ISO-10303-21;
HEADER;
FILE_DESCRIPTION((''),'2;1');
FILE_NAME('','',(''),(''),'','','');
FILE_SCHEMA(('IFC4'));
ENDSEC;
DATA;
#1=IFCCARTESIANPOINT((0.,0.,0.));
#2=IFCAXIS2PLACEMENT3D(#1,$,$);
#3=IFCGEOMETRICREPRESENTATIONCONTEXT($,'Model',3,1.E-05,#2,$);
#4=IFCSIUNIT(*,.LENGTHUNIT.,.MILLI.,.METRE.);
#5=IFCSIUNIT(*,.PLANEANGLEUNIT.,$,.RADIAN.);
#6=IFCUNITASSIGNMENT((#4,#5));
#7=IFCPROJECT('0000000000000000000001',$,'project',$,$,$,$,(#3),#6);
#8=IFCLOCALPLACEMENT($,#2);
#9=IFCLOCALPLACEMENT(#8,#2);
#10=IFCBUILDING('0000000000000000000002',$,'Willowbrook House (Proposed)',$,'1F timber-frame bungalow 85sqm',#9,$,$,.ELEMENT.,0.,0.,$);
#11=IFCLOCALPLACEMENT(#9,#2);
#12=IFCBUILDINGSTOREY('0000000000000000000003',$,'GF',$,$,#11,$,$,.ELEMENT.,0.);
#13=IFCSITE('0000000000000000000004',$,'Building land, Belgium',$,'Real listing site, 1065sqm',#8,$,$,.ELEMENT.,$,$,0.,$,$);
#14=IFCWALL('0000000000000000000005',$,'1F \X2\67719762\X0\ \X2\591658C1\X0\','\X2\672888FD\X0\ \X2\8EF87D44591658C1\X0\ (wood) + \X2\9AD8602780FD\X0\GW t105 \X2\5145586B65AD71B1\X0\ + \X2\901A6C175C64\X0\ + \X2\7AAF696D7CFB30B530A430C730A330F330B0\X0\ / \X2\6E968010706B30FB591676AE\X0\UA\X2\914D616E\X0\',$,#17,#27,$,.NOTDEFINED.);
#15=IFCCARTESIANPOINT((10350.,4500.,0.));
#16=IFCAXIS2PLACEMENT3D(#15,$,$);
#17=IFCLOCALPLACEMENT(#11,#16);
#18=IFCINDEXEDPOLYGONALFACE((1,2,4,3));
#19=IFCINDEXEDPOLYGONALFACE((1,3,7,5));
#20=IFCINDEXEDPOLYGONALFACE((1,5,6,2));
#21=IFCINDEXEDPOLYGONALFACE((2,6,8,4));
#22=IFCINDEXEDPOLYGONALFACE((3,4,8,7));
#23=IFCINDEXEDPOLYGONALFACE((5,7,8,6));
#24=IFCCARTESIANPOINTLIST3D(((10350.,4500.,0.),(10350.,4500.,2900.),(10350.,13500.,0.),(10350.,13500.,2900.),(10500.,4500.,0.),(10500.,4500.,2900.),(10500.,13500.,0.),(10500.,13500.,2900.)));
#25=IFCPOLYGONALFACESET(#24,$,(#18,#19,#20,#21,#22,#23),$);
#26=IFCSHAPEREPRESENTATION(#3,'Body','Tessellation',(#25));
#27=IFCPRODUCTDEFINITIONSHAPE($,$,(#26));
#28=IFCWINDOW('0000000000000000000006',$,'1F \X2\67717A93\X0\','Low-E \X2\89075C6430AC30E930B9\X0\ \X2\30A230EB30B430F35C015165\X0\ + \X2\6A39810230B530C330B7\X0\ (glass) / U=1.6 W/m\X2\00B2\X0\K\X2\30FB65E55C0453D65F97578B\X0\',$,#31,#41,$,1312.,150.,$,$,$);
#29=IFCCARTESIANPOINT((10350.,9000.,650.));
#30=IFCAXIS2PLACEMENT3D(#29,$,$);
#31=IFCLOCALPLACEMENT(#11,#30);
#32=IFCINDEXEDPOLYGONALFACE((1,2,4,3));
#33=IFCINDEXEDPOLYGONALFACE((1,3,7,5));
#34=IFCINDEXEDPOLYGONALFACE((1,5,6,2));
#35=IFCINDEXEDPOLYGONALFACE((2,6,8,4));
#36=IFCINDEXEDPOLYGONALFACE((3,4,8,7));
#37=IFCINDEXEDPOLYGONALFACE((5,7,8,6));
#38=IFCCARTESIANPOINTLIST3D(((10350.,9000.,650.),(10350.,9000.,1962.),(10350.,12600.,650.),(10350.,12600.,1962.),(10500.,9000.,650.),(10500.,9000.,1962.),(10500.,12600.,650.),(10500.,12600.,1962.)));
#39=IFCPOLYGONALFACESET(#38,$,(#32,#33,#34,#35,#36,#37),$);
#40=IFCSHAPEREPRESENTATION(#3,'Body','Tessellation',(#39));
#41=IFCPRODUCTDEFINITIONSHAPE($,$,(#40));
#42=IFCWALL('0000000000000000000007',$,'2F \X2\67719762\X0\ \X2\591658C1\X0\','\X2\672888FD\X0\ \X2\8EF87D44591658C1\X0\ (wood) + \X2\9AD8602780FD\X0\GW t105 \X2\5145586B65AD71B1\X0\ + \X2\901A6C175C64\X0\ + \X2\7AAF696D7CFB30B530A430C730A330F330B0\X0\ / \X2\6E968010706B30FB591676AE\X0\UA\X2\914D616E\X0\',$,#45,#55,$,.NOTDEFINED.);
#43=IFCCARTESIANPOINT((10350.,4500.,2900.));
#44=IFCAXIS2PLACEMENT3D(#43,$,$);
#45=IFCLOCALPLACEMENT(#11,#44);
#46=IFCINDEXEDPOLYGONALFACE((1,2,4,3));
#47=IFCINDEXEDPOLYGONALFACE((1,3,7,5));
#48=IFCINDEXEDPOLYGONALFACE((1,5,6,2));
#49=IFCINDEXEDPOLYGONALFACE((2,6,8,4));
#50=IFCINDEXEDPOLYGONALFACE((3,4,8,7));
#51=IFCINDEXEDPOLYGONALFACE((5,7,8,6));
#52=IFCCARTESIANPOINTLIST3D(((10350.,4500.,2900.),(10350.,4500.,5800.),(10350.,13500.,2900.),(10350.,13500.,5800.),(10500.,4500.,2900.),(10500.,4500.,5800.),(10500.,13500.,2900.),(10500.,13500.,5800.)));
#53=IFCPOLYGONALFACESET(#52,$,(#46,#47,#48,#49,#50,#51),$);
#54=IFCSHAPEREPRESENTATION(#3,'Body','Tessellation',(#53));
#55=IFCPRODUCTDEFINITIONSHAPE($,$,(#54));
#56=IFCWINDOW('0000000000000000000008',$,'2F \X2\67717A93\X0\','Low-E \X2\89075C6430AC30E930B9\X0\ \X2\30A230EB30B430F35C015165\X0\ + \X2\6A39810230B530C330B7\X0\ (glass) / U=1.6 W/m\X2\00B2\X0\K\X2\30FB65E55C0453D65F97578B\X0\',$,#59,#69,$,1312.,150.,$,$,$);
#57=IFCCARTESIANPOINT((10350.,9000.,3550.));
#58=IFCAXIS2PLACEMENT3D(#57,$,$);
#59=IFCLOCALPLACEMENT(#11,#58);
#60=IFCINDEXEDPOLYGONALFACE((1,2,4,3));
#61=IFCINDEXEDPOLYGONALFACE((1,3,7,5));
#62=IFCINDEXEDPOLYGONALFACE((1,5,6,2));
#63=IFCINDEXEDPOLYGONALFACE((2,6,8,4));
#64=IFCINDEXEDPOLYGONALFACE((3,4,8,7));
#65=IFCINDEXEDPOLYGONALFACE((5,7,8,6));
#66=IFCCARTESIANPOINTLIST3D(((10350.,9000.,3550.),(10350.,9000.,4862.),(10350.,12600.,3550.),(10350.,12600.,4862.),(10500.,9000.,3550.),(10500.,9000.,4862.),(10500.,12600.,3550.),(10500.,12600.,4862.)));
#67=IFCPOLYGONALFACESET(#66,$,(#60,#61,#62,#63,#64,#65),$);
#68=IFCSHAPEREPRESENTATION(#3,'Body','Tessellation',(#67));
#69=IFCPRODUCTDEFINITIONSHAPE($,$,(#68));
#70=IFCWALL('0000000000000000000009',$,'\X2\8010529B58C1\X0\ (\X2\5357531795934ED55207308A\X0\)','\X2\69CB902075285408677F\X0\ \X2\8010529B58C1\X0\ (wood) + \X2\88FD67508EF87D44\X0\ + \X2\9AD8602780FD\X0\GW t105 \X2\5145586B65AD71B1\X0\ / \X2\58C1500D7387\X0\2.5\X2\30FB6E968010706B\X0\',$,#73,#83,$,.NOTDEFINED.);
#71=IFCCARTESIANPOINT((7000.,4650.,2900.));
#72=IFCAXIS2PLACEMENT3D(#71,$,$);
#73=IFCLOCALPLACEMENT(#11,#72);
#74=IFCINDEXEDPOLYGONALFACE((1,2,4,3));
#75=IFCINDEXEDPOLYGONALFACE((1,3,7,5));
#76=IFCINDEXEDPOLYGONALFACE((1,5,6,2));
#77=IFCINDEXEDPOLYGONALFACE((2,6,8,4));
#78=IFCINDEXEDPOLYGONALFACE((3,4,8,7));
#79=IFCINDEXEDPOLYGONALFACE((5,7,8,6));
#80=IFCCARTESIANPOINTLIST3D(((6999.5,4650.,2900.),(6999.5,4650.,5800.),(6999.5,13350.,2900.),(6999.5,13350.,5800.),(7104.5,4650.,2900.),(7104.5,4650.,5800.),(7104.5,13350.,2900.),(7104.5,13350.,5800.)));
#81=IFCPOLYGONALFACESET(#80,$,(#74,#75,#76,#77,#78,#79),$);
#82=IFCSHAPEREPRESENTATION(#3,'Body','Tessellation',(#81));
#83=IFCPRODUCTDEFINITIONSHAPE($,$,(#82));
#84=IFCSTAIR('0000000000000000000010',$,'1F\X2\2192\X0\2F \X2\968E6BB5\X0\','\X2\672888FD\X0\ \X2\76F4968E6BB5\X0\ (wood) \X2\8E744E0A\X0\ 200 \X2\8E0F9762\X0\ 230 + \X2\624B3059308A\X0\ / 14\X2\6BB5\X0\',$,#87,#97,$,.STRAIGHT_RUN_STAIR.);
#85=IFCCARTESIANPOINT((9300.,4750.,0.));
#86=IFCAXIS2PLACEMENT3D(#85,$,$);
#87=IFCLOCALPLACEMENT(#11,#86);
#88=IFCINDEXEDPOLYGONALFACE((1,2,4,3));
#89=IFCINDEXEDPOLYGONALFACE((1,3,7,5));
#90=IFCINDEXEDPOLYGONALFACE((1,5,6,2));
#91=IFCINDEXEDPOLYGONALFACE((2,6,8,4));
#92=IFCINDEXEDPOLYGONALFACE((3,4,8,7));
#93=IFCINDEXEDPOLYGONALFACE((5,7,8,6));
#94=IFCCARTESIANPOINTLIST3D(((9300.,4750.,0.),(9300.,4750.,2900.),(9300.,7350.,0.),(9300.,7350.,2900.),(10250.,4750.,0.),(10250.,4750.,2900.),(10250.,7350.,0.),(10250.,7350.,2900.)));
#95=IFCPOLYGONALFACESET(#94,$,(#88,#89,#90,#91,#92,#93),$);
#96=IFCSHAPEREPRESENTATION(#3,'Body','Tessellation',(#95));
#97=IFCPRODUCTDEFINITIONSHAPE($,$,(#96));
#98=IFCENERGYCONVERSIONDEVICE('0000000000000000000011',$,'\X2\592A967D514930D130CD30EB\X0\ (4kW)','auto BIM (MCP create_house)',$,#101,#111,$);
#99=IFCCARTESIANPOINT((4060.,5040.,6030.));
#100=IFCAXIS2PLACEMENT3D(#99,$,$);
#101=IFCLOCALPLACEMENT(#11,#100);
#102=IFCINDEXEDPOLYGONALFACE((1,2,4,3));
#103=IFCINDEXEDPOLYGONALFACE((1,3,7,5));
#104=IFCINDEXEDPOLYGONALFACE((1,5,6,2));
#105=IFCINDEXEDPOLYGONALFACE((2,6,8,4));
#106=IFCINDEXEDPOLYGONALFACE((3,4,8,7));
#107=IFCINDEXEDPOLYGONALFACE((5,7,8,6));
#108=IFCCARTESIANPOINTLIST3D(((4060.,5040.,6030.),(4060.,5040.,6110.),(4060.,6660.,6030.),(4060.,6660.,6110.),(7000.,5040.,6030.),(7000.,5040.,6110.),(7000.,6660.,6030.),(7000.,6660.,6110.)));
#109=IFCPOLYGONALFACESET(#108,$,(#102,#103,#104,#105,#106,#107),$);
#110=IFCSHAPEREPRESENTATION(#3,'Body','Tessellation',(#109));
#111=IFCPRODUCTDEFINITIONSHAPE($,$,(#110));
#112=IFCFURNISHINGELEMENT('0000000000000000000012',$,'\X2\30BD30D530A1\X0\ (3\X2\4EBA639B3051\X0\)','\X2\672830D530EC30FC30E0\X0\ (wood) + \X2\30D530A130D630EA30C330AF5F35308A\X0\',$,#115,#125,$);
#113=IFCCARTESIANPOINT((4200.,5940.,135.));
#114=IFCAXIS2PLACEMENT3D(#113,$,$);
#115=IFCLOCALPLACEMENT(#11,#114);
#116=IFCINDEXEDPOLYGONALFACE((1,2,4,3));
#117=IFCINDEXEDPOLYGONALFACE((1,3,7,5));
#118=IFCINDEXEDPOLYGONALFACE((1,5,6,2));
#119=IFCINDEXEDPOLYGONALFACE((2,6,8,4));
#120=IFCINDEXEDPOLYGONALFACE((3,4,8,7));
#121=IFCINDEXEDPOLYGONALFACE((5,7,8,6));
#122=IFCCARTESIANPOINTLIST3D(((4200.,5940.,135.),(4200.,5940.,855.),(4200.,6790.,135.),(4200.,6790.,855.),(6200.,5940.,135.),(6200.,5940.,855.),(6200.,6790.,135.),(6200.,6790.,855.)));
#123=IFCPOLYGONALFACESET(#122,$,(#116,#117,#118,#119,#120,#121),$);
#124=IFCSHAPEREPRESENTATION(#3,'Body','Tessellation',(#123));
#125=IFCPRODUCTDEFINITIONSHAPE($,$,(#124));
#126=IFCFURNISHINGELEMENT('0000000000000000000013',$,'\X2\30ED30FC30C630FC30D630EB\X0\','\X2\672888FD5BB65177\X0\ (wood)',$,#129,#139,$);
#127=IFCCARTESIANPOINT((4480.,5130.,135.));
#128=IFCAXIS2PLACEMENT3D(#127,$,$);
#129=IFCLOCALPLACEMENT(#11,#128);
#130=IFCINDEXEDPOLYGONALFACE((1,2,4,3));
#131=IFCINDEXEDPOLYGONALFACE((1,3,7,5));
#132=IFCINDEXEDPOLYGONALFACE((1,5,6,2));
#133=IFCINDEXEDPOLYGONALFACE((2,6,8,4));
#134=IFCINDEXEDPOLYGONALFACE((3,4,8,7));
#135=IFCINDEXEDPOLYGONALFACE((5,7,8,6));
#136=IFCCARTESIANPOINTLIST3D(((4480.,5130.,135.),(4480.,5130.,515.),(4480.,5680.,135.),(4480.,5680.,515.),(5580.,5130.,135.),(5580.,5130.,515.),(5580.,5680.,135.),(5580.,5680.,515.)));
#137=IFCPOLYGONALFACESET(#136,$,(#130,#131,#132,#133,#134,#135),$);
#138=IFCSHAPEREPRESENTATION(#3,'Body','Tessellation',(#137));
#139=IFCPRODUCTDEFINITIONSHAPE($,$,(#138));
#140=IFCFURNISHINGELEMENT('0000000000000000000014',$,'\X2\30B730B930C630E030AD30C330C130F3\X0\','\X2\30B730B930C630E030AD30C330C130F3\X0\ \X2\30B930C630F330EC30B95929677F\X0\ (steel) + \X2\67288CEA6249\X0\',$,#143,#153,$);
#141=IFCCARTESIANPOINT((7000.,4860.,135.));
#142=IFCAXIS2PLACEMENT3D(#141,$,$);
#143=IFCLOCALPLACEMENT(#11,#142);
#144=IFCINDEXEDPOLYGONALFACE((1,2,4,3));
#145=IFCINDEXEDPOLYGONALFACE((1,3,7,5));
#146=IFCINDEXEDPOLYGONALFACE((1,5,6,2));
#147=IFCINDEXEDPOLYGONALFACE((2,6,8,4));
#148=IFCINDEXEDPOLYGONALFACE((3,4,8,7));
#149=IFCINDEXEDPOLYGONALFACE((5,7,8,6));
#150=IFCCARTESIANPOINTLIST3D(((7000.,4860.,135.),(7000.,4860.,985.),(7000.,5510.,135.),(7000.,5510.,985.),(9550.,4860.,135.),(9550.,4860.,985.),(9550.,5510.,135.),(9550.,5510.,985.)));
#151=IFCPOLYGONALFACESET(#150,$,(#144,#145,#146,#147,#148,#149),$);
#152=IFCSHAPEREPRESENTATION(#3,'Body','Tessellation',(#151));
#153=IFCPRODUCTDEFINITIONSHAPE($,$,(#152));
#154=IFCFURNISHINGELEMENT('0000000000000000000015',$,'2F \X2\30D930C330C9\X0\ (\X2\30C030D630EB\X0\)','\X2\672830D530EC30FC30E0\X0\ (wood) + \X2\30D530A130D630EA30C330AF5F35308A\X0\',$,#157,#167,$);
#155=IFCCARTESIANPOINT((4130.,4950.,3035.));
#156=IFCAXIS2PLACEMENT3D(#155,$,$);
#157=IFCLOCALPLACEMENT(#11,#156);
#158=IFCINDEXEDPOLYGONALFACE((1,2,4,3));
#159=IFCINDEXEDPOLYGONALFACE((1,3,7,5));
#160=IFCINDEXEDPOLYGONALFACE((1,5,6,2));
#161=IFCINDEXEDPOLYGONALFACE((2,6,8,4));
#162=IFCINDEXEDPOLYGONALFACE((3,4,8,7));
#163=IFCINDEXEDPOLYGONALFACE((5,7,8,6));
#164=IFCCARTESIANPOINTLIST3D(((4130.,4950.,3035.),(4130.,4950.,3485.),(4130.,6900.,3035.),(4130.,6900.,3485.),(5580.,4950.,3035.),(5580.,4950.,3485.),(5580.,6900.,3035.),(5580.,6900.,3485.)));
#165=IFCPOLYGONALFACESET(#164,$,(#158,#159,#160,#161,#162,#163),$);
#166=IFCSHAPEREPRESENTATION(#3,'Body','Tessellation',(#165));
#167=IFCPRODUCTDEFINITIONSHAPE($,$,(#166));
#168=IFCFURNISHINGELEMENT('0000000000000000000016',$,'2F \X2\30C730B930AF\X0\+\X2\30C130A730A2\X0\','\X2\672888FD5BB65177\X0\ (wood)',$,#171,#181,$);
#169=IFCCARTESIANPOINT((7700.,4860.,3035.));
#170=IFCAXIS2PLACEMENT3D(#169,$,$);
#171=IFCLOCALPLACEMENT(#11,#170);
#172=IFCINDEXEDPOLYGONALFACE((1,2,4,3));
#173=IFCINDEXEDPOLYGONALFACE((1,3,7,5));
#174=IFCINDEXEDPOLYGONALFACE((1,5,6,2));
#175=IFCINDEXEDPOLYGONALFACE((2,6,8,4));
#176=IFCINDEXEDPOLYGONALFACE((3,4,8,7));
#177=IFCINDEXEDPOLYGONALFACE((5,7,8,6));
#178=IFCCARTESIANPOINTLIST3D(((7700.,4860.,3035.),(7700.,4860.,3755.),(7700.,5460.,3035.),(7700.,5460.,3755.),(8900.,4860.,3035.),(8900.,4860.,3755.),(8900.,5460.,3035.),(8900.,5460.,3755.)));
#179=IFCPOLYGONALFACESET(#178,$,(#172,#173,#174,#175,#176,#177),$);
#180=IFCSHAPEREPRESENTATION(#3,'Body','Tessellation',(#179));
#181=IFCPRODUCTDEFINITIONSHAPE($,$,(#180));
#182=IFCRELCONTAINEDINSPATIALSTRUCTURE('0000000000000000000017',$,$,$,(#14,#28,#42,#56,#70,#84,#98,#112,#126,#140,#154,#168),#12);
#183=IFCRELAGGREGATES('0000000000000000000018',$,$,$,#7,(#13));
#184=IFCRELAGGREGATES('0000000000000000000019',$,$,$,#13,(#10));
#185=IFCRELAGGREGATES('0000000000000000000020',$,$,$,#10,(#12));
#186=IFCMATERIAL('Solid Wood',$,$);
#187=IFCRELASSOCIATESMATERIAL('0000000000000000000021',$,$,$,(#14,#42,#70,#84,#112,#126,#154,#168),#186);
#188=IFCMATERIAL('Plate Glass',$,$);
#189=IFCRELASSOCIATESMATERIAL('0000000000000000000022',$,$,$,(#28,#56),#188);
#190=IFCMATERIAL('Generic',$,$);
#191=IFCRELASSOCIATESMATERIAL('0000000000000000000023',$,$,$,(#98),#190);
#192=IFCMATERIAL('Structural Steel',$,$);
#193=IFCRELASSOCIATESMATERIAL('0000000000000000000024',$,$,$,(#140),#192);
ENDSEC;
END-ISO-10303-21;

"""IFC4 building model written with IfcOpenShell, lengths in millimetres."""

from ifc_helpers import new_model, si_unit, frame, frame_2d, origin, place, context, project, spatial, rectangle, extrude, material, element, fill, save


model = new_model("IFC4")

# Units and contexts
model_context = context("Model", 3, precision=1e-05, world=origin())
ifc_project = project(units=[si_unit("LENGTHUNIT", "METRE", prefix="MILLI"), si_unit("PLANEANGLEUNIT", "RADIAN")], contexts=[model_context])

# Site, building, storey
site_placement = place(None, origin())
site = spatial("IfcSite", under=ifc_project, at=site_placement, Name="Building land, Belgium", ObjectType="Real listing site, 1065sqm", CompositionType="ELEMENT", RefElevation=0.0)
building_placement = place(site_placement, origin())
building = spatial("IfcBuilding", under=site, at=building_placement, Name="Willowbrook House (Proposed)", ObjectType="1F timber-frame bungalow 85sqm", CompositionType="ELEMENT", ElevationOfRefHeight=0.0, ElevationOfTerrain=0.0)
storey_placement = place(building_placement, origin())
storey = spatial("IfcBuildingStorey", under=building, at=storey_placement, Name="GF", CompositionType="ELEMENT", Elevation=0.0)

# Wall, opening, window
ifc_material_1 = material(Name="Solid Wood")
wall_1_placement = place(storey_placement, frame((10350.0, 4500.0, 0.0)))
wall_1 = element("IfcWall", 1, at=wall_1_placement, inside=storey, material=ifc_material_1, Name="1F 東面 外壁", Description="木製 軸組外壁 (wood) + 高性能GW t105 充填断熱 + 通気層 + 窯業系サイディング / 準耐火・外皮UA配慮", PredefinedType="NOTDEFINED", context=model_context, shape_type="SweptSolid", body=[
    extrude(rectangle(XDim=150.0, YDim=9000.0, at=frame_2d((75.0, 4500.0))), frame((10350.0, 4500.0, 0.0)), (0.0, 0.0, 1.0), 2900.0),
])
opening_1_placement = place(storey_placement, frame((10350.0, 9000.0, 650.0)))
opening_1 = element("IfcOpeningElement", 2, at=opening_1_placement, cuts=wall_1, PredefinedType="NOTDEFINED", context=model_context, shape_type="SweptSolid", body=[
    extrude(rectangle(XDim=150.0, YDim=3600.0, at=frame_2d((75.0, 1800.0))), frame((10350.0, 9000.0, 650.0)), (0.0, 0.0, 1.0), 1312.0),
])
ifc_material_2 = material(Name="Plate Glass")
window_1_placement = place(storey_placement, frame((10350.0, 9000.0, 650.0)))
window_1 = element("IfcWindow", 3, at=window_1_placement, inside=storey, material=ifc_material_2, Name="1F 東窓", Description="Low-E 複層ガラス アルゴン封入 + 樹脂サッシ (glass) / U=1.6 W/m²K・日射取得型", OverallHeight=1312.0, OverallWidth=150.0, context=model_context, shape_type="SweptSolid", body=[
    extrude(rectangle(XDim=150.0, YDim=3600.0, at=frame_2d((75.0, 1800.0))), frame((10350.0, 9000.0, 650.0)), (0.0, 0.0, 1.0), 1312.0),
])
fill(opening_1, window_1)

# Wall, opening, window
wall_2_placement = place(storey_placement, frame((10350.0, 4500.0, 2900.0)))
wall_2 = element("IfcWall", 4, at=wall_2_placement, inside=storey, material=ifc_material_1, Name="2F 東面 外壁", Description="木製 軸組外壁 (wood) + 高性能GW t105 充填断熱 + 通気層 + 窯業系サイディング / 準耐火・外皮UA配慮", PredefinedType="NOTDEFINED", context=model_context, shape_type="SweptSolid", body=[
    extrude(rectangle(XDim=150.0, YDim=9000.0, at=frame_2d((75.0, 4500.0))), frame((10350.0, 4500.0, 2900.0)), (0.0, 0.0, 1.0), 2900.0),
])
opening_2_placement = place(storey_placement, frame((10350.0, 9000.0, 3550.0)))
opening_2 = element("IfcOpeningElement", 5, at=opening_2_placement, cuts=wall_2, PredefinedType="NOTDEFINED", context=model_context, shape_type="SweptSolid", body=[
    extrude(rectangle(XDim=150.0, YDim=3600.0, at=frame_2d((75.0, 1800.0))), frame((10350.0, 9000.0, 3550.0)), (0.0, 0.0, 1.0), 1312.0),
])
window_2_placement = place(storey_placement, frame((10350.0, 9000.0, 3550.0)))
window_2 = element("IfcWindow", 6, at=window_2_placement, inside=storey, material=ifc_material_2, Name="2F 東窓", Description="Low-E 複層ガラス アルゴン封入 + 樹脂サッシ (glass) / U=1.6 W/m²K・日射取得型", OverallHeight=1312.0, OverallWidth=150.0, context=model_context, shape_type="SweptSolid", body=[
    extrude(rectangle(XDim=150.0, YDim=3600.0, at=frame_2d((75.0, 1800.0))), frame((10350.0, 9000.0, 3550.0)), (0.0, 0.0, 1.0), 1312.0),
])
fill(opening_2, window_2)

# Wall
wall_3_placement = place(storey_placement, frame((7000.0, 4650.0, 2900.0)))
element("IfcWall", 7, at=wall_3_placement, inside=storey, material=ifc_material_1, Name="耐力壁 (南北間仕切り)", Description="構造用合板 耐力壁 (wood) + 製材軸組 + 高性能GW t105 充填断熱 / 壁倍率2.5・準耐火", PredefinedType="NOTDEFINED", context=model_context, shape_type="SweptSolid", body=[
    extrude(rectangle(XDim=105.0, YDim=8700.0, at=frame_2d((52.0, 4350.0))), frame((7000.0, 4650.0, 2900.0)), (0.0, 0.0, 1.0), 2900.0),
])

# Stair
stair_placement = place(storey_placement, frame((9300.0, 4750.0, 0.0)))
element("IfcStair", 8, at=stair_placement, inside=storey, material=ifc_material_1, Name="1F→2F 階段", Description="木製 直階段 (wood) 蹴上 200 踏面 230 + 手すり / 14段", PredefinedType="STRAIGHT_RUN_STAIR", context=model_context, shape_type="SweptSolid", body=[
    extrude(rectangle(XDim=950.0, YDim=2600.0, at=frame_2d((475.0, 1300.0))), frame((9300.0, 4750.0, 0.0)), (0.0, 0.0, 1.0), 2900.0),
])

# Energy conversion device
ifc_material_3 = material(Name="Generic")
energy_conversion_device_placement = place(storey_placement, frame((4060.0, 5040.0, 6030.0)))
element("IfcEnergyConversionDevice", 9, at=energy_conversion_device_placement, inside=storey, material=ifc_material_3, Name="太陽光パネル (4kW)", Description="auto BIM (MCP create_house)", context=model_context, shape_type="SweptSolid", body=[
    extrude(rectangle(XDim=2940.0, YDim=1620.0, at=frame_2d((1470.0, 810.0))), frame((4060.0, 5040.0, 6030.0)), (0.0, 0.0, 1.0), 80.0),
])

# Furnishing elements
furnishing_1_placement = place(storey_placement, frame((4200.0, 5940.0, 135.0)))
element("IfcFurnishingElement", 10, at=furnishing_1_placement, inside=storey, material=ifc_material_1, Name="ソファ (3人掛け)", Description="木フレーム (wood) + ファブリック張り", context=model_context, shape_type="SweptSolid", body=[
    extrude(rectangle(XDim=2000.0, YDim=850.0, at=frame_2d((1000.0, 425.0))), frame((4200.0, 5940.0, 135.0)), (0.0, 0.0, 1.0), 720.0),
])
furnishing_2_placement = place(storey_placement, frame((4480.0, 5130.0, 135.0)))
element("IfcFurnishingElement", 11, at=furnishing_2_placement, inside=storey, material=ifc_material_1, Name="ローテーブル", Description="木製家具 (wood)", context=model_context, shape_type="SweptSolid", body=[
    extrude(rectangle(XDim=1100.0, YDim=550.0, at=frame_2d((550.0, 275.0))), frame((4480.0, 5130.0, 135.0)), (0.0, 0.0, 1.0), 380.0),
])
ifc_material_4 = material(Name="Structural Steel")
furnishing_3_placement = place(storey_placement, frame((7000.0, 4860.0, 135.0)))
element("IfcFurnishingElement", 12, at=furnishing_3_placement, inside=storey, material=ifc_material_4, Name="システムキッチン", Description="システムキッチン ステンレス天板 (steel) + 木質扉", context=model_context, shape_type="SweptSolid", body=[
    extrude(rectangle(XDim=2550.0, YDim=650.0, at=frame_2d((1275.0, 325.0))), frame((7000.0, 4860.0, 135.0)), (0.0, 0.0, 1.0), 850.0),
])
furnishing_4_placement = place(storey_placement, frame((4130.0, 4950.0, 3035.0)))
element("IfcFurnishingElement", 13, at=furnishing_4_placement, inside=storey, material=ifc_material_1, Name="2F ベッド (ダブル)", Description="木フレーム (wood) + ファブリック張り", context=model_context, shape_type="SweptSolid", body=[
    extrude(rectangle(XDim=1450.0, YDim=1950.0, at=frame_2d((725.0, 975.0))), frame((4130.0, 4950.0, 3035.0)), (0.0, 0.0, 1.0), 450.0),
])
furnishing_5_placement = place(storey_placement, frame((7700.0, 4860.0, 3035.0)))
element("IfcFurnishingElement", 14, at=furnishing_5_placement, inside=storey, material=ifc_material_1, Name="2F デスク+チェア", Description="木製家具 (wood)", context=model_context, shape_type="SweptSolid", body=[
    extrude(rectangle(XDim=1200.0, YDim=600.0, at=frame_2d((600.0, 300.0))), frame((7700.0, 4860.0, 3035.0)), (0.0, 0.0, 1.0), 720.0),
])

save(model, "model.ifc")
